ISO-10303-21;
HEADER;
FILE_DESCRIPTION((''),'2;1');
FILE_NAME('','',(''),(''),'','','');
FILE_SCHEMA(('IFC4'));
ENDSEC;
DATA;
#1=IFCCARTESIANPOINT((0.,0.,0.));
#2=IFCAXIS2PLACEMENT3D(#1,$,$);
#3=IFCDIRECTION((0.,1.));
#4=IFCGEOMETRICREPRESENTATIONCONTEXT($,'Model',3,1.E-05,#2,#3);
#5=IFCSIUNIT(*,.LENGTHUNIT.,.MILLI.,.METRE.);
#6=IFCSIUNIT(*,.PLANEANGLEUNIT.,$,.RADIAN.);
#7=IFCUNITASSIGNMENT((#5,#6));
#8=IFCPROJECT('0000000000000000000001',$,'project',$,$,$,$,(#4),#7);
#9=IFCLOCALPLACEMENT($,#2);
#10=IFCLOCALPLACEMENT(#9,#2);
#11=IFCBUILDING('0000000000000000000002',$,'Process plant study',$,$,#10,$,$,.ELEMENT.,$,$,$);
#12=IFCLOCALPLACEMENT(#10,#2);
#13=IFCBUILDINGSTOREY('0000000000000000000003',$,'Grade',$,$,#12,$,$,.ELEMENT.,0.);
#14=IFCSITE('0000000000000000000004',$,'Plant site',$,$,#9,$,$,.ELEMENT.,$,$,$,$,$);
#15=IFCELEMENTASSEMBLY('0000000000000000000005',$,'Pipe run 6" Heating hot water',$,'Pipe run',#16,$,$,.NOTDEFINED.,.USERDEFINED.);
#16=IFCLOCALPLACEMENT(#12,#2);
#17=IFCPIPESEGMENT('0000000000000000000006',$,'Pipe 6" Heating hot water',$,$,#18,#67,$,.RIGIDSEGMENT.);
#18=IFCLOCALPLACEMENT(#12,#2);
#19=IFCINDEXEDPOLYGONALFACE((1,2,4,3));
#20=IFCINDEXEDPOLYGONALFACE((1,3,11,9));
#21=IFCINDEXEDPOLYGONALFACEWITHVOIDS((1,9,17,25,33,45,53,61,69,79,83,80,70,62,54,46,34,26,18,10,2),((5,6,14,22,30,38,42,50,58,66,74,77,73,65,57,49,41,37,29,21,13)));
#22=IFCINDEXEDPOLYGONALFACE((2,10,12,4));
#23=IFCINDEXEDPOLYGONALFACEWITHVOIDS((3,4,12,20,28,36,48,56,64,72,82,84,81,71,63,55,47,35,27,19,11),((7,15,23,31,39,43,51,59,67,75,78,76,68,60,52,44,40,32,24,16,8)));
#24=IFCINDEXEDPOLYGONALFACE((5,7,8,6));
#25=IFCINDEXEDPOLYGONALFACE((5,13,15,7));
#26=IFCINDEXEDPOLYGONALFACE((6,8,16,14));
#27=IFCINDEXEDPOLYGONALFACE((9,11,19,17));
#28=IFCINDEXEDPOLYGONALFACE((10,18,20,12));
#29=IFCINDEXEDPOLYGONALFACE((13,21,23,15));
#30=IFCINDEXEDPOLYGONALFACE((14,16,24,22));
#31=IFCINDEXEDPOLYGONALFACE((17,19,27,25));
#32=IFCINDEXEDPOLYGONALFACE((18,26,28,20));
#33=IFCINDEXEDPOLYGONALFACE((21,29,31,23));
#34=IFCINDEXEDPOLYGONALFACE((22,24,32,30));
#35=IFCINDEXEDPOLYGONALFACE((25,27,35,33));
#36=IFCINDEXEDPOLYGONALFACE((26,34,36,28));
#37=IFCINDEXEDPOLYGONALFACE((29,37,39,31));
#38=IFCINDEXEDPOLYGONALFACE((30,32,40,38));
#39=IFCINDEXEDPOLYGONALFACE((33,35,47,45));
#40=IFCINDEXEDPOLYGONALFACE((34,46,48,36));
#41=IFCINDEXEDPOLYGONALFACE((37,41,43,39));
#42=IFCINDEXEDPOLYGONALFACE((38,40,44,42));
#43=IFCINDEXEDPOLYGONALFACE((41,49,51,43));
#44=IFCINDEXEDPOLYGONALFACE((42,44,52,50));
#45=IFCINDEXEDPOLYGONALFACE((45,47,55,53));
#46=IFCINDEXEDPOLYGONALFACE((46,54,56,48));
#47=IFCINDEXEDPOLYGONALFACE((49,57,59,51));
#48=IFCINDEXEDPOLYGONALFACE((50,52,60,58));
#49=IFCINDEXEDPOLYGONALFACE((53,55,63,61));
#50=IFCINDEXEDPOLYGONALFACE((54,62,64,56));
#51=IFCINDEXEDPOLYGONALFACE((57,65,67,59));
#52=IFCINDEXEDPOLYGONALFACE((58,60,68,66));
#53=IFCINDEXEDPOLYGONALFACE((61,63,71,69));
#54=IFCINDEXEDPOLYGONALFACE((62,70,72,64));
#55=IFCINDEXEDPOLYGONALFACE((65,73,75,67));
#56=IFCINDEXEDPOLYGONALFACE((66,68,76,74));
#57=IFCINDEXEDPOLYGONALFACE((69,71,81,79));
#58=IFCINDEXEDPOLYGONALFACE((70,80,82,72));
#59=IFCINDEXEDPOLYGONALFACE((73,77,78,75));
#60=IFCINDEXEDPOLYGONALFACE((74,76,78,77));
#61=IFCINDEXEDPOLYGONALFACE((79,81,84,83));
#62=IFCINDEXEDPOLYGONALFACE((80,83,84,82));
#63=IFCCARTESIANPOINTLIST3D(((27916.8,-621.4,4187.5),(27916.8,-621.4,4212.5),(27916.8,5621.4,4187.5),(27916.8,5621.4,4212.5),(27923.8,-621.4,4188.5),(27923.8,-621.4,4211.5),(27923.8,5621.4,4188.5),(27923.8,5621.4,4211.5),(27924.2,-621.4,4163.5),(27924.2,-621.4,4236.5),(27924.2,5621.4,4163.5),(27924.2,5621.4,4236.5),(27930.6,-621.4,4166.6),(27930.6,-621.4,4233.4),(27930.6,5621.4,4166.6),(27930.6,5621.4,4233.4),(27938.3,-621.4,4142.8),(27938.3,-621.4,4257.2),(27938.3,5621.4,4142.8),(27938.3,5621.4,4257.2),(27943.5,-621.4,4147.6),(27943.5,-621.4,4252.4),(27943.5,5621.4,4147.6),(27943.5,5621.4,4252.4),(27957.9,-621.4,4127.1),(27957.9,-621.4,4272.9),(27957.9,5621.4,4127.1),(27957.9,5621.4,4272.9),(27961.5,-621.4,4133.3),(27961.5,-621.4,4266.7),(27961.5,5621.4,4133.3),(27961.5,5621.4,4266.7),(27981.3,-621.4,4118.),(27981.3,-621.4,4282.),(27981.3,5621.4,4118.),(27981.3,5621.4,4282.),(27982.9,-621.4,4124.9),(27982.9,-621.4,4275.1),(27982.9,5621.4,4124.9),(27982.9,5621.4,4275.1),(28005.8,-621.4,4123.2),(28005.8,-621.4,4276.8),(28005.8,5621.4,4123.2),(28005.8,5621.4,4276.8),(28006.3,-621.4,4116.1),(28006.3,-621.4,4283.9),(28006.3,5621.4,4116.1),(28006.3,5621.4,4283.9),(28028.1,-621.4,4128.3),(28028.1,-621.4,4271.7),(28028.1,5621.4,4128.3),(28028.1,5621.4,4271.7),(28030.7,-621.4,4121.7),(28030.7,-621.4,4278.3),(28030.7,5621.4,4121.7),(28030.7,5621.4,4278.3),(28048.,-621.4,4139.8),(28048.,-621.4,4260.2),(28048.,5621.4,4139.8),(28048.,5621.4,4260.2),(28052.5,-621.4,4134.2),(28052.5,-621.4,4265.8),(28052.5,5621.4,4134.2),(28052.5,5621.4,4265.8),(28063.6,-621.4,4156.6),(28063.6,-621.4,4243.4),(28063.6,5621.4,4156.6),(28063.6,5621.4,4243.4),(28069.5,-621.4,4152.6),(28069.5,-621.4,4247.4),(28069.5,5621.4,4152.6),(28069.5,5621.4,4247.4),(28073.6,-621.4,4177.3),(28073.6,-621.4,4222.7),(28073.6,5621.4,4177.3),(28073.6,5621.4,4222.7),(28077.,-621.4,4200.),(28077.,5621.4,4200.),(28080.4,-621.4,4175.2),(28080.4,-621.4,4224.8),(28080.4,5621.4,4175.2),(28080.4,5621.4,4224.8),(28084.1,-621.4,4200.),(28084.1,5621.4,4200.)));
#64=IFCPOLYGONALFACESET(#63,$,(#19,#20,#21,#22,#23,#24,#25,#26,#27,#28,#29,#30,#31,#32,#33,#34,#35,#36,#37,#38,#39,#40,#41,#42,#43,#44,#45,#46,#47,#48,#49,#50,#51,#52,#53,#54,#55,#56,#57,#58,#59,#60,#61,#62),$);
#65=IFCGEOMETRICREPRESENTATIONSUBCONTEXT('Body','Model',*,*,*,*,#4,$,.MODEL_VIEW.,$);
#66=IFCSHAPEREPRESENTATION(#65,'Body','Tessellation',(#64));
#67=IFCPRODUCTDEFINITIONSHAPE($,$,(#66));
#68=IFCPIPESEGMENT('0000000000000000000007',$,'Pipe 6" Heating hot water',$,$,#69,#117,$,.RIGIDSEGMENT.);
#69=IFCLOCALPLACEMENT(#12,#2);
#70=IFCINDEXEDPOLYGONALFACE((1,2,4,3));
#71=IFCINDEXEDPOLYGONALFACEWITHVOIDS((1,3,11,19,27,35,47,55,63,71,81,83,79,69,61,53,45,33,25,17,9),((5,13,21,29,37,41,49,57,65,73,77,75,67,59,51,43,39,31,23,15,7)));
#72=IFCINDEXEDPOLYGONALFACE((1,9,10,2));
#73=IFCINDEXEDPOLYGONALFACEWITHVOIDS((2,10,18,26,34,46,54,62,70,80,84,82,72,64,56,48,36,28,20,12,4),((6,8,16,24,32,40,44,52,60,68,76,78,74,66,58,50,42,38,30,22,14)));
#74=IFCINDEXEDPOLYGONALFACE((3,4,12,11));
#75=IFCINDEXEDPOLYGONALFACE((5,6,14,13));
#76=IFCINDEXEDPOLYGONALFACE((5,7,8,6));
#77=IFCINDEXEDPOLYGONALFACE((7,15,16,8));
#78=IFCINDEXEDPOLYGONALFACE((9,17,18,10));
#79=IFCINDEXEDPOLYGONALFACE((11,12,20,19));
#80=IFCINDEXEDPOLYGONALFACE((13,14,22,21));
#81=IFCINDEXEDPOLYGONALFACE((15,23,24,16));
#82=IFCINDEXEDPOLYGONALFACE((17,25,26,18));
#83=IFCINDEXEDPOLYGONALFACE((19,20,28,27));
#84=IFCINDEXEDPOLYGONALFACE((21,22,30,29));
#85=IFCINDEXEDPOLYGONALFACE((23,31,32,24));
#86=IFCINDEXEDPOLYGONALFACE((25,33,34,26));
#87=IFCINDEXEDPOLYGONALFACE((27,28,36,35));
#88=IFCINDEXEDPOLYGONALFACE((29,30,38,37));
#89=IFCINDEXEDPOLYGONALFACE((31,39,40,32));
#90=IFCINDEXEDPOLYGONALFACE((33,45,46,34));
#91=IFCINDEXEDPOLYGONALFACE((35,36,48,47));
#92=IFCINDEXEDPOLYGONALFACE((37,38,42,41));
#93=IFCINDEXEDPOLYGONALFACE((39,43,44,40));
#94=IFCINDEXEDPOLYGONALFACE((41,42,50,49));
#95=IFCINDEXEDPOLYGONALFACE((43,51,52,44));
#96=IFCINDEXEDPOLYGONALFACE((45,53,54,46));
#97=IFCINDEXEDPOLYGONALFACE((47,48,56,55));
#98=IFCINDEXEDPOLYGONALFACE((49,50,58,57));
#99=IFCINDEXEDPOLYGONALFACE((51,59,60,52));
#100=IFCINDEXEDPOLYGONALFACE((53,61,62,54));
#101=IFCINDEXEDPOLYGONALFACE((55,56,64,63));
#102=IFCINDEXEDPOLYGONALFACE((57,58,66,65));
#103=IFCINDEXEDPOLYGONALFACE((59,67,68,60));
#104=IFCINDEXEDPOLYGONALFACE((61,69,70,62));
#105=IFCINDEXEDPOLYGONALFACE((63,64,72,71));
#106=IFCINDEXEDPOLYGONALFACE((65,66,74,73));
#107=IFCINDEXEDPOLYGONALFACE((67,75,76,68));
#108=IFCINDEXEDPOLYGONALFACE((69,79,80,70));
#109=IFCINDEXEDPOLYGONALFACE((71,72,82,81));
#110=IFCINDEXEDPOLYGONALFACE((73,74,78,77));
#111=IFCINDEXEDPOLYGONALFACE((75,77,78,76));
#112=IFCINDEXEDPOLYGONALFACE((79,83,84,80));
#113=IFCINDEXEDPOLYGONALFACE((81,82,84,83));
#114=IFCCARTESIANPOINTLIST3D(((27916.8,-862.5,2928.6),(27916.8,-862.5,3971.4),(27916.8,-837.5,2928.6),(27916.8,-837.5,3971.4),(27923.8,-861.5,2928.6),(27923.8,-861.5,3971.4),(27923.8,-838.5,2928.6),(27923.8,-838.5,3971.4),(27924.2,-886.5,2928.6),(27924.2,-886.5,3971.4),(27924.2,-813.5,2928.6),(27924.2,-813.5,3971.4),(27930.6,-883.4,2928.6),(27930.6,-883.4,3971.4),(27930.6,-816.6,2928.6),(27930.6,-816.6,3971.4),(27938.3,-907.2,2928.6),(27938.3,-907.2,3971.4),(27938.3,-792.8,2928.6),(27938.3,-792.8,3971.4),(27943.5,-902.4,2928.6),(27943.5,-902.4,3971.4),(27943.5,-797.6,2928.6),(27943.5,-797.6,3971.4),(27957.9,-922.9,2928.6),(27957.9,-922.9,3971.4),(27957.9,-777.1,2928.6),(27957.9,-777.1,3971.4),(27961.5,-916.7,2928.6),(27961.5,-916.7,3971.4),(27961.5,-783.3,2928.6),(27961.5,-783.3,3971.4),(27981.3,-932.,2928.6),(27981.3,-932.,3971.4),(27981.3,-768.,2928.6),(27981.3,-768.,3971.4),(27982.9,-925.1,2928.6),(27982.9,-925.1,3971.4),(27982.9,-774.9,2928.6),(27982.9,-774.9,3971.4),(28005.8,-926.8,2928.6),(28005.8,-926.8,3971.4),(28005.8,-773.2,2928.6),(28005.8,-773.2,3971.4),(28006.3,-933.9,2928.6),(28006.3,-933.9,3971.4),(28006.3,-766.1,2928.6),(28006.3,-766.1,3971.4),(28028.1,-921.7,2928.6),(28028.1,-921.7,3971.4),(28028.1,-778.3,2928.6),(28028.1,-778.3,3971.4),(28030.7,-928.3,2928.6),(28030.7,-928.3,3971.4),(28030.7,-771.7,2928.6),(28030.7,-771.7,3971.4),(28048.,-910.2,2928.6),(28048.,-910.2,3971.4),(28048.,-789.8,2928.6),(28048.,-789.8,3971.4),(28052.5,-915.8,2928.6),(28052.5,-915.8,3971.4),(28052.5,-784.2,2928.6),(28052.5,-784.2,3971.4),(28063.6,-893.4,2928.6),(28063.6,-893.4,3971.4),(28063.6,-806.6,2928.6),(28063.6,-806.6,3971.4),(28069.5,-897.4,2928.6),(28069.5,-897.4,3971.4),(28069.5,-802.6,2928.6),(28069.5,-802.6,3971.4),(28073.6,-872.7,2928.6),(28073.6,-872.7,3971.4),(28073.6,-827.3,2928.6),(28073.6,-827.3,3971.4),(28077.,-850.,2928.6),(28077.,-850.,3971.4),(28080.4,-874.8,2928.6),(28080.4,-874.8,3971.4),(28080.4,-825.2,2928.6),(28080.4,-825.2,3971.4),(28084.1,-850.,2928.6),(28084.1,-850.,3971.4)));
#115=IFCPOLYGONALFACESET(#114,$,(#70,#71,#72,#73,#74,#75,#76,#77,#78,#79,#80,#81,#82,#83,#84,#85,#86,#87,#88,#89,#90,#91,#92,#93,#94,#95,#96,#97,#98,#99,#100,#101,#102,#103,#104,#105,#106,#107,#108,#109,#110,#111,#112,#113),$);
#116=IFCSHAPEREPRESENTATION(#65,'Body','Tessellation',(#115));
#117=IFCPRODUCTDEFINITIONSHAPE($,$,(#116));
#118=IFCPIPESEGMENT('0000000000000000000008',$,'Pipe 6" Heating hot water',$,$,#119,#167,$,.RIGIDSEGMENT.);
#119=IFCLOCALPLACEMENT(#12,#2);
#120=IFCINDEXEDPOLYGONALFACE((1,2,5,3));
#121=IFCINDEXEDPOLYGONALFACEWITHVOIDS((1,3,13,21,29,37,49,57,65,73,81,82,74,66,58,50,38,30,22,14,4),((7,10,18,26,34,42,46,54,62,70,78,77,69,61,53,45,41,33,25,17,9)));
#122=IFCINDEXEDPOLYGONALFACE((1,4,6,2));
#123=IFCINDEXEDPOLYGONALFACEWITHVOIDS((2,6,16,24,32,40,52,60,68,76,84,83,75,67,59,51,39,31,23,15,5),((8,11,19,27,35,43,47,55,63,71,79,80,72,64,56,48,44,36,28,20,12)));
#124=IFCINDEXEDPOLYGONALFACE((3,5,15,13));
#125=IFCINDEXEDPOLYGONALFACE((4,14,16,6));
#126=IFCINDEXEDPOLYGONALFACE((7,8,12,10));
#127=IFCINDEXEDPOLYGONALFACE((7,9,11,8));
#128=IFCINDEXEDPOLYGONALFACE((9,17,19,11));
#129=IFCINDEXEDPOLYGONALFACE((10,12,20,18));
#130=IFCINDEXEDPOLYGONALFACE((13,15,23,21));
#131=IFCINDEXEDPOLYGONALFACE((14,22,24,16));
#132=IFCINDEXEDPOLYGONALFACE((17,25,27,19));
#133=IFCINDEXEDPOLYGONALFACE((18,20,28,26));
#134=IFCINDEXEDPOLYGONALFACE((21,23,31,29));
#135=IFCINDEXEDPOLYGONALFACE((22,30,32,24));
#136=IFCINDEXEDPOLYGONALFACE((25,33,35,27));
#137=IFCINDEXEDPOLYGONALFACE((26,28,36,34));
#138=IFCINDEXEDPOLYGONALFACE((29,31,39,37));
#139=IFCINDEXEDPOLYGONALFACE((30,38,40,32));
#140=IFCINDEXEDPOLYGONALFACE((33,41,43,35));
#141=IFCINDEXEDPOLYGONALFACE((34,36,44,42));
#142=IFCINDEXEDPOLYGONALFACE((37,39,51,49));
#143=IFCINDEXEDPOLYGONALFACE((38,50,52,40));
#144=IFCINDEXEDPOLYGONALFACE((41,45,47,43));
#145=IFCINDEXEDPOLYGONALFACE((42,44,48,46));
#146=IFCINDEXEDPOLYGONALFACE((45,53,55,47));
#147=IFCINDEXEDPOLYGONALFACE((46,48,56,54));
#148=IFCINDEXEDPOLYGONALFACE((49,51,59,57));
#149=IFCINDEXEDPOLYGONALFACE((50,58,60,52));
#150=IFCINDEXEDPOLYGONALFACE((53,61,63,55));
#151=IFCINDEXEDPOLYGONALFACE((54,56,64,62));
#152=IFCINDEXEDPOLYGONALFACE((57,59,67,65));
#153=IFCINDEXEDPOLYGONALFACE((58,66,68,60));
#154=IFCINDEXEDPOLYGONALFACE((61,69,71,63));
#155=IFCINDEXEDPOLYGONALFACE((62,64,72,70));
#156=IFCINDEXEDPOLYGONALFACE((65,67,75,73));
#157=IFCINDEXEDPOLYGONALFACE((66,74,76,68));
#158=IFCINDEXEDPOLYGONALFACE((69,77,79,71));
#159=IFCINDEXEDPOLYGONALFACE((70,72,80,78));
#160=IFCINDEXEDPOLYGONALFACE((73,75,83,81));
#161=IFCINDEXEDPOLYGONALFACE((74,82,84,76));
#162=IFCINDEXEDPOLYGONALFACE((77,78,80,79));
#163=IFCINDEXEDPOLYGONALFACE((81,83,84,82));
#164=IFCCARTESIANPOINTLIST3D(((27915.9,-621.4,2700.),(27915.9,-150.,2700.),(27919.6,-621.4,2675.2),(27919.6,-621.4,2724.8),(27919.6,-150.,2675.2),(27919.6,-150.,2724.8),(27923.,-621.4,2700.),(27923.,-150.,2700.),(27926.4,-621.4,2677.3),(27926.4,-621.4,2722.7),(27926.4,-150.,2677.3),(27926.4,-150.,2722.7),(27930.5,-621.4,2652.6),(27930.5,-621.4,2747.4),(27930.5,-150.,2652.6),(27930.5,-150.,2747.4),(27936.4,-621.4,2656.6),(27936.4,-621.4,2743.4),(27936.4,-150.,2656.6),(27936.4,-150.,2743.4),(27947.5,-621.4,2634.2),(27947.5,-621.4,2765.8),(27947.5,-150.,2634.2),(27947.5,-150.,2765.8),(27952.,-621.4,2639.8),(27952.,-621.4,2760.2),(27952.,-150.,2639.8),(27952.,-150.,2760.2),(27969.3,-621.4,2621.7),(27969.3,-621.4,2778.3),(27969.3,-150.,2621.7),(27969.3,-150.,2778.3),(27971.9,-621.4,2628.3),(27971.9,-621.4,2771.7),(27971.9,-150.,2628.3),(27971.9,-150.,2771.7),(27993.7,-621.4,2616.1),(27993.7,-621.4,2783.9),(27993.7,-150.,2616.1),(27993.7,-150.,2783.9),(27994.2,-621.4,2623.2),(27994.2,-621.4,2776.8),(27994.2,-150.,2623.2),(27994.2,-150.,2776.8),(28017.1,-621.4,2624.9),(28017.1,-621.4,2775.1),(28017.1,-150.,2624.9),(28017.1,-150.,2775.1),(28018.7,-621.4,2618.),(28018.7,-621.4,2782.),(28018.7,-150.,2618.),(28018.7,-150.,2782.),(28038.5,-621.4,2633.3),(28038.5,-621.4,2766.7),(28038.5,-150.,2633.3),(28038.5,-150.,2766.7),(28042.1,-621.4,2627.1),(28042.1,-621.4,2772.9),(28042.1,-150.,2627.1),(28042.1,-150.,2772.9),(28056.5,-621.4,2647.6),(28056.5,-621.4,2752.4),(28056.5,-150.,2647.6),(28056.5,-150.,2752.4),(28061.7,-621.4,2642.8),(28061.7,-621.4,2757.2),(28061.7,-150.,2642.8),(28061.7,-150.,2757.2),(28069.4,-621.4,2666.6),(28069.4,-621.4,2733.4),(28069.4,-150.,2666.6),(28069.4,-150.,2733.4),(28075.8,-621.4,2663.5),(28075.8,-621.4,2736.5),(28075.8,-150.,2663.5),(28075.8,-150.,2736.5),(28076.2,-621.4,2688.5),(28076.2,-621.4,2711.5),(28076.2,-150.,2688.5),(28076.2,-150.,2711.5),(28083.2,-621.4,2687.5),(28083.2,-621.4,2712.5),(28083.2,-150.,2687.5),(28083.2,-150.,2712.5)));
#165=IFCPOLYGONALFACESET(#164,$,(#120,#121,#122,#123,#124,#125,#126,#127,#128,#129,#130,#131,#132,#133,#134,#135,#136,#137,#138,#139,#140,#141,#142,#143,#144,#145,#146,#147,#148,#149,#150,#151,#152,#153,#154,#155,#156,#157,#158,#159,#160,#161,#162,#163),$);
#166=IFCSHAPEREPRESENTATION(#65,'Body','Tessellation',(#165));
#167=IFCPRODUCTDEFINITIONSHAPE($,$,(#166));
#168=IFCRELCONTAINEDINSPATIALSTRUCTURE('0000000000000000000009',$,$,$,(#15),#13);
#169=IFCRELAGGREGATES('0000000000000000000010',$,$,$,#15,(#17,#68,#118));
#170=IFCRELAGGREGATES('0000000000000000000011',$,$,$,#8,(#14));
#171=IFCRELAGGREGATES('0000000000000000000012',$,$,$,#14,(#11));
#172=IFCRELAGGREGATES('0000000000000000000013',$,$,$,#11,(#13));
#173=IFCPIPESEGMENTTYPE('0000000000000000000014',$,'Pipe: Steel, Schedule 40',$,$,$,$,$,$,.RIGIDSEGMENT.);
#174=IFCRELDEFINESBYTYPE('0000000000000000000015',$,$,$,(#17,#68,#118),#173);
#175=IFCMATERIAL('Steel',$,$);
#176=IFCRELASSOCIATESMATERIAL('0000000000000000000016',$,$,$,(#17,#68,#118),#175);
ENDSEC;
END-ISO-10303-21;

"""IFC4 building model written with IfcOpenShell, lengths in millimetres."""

from ifc_helpers import new_model, si_unit, direction, frame, origin, origin_with_axes, origin_2d, place, context, subcontext, project, spatial, hollow_circle, extrude, material, type_object, element, aggregate, save


model = new_model("IFC4")

# Units and contexts
model_context = context("Model", 3, precision=1e-05, world=origin(), true_north=direction((0.0, 1.0)))
body_context = subcontext(model_context, "Body", "Model", "MODEL_VIEW")
ifc_project = project(units=[si_unit("LENGTHUNIT", "METRE", prefix="MILLI"), si_unit("PLANEANGLEUNIT", "RADIAN")], contexts=[model_context])

# Site, building, storey
site_placement = place(None, origin())
site = spatial("IfcSite", under=ifc_project, at=site_placement, Name="Plant site", CompositionType="ELEMENT")
building_placement = place(site_placement, origin())
building = spatial("IfcBuilding", under=site, at=building_placement, Name="Process plant study", CompositionType="ELEMENT")
storey_placement = place(building_placement, origin())
storey = spatial("IfcBuildingStorey", under=building, at=storey_placement, Name="Grade", CompositionType="ELEMENT", Elevation=0.0)

# Element assembly, pipe segments
ifc_material = material(Name="Steel")
pipe_segment_type = type_object("IfcPipeSegmentType", Name="Pipe: Steel, Schedule 40", PredefinedType="RIGIDSEGMENT")
assembly_1_placement = place(storey_placement, origin_with_axes())
assembly_1 = element("IfcElementAssembly", 1, at=assembly_1_placement, inside=storey, Name="Pipe run 6\" Heating hot water", ObjectType="Pipe run", AssemblyPlace="NOTDEFINED", PredefinedType="USERDEFINED")
pipe_segment_1_placement = place(storey_placement, origin_with_axes())
pipe_segment_1 = element("IfcPipeSegment", 2, at=pipe_segment_1_placement, type_object=pipe_segment_type, material=ifc_material, Name="Pipe 6\" Heating hot water", PredefinedType="RIGIDSEGMENT", context=body_context, shape_type="SweptSolid", body=[
    extrude(hollow_circle(Radius=84.1, WallThickness=7.1, at=origin_2d()), frame((28000.0, 5621.4, 4200.0), z_axis=(0.0, -1.0, 0.0), x_axis=(1.0, 0.0, 0.0)), (0.0, 0.0, 1.0), 6242.8),
])
pipe_segment_2_placement = place(storey_placement, origin_with_axes())
pipe_segment_2 = element("IfcPipeSegment", 3, at=pipe_segment_2_placement, type_object=pipe_segment_type, material=ifc_material, Name="Pipe 6\" Heating hot water", PredefinedType="RIGIDSEGMENT", context=body_context, shape_type="SweptSolid", body=[
    extrude(hollow_circle(Radius=84.1, WallThickness=7.1, at=origin_2d()), frame((28000.0, -850.0, 3971.4), z_axis=(0.0, 0.0, -1.0), x_axis=(1.0, 0.0, 0.0)), (0.0, 0.0, 1.0), 1042.8),
])
pipe_segment_3_placement = place(storey_placement, origin_with_axes())
pipe_segment_3 = element("IfcPipeSegment", 4, at=pipe_segment_3_placement, type_object=pipe_segment_type, material=ifc_material, Name="Pipe 6\" Heating hot water", PredefinedType="RIGIDSEGMENT", context=body_context, shape_type="SweptSolid", body=[
    extrude(hollow_circle(Radius=84.1, WallThickness=7.1, at=origin_2d()), frame((28000.0, -621.4, 2700.0), z_axis=(0.0, 1.0, 0.0), x_axis=(-1.0, 0.0, 0.0)), (0.0, 0.0, 1.0), 471.4),
])

aggregate(assembly_1, [pipe_segment_1, pipe_segment_2, pipe_segment_3])

save(model, "model.ifc")
